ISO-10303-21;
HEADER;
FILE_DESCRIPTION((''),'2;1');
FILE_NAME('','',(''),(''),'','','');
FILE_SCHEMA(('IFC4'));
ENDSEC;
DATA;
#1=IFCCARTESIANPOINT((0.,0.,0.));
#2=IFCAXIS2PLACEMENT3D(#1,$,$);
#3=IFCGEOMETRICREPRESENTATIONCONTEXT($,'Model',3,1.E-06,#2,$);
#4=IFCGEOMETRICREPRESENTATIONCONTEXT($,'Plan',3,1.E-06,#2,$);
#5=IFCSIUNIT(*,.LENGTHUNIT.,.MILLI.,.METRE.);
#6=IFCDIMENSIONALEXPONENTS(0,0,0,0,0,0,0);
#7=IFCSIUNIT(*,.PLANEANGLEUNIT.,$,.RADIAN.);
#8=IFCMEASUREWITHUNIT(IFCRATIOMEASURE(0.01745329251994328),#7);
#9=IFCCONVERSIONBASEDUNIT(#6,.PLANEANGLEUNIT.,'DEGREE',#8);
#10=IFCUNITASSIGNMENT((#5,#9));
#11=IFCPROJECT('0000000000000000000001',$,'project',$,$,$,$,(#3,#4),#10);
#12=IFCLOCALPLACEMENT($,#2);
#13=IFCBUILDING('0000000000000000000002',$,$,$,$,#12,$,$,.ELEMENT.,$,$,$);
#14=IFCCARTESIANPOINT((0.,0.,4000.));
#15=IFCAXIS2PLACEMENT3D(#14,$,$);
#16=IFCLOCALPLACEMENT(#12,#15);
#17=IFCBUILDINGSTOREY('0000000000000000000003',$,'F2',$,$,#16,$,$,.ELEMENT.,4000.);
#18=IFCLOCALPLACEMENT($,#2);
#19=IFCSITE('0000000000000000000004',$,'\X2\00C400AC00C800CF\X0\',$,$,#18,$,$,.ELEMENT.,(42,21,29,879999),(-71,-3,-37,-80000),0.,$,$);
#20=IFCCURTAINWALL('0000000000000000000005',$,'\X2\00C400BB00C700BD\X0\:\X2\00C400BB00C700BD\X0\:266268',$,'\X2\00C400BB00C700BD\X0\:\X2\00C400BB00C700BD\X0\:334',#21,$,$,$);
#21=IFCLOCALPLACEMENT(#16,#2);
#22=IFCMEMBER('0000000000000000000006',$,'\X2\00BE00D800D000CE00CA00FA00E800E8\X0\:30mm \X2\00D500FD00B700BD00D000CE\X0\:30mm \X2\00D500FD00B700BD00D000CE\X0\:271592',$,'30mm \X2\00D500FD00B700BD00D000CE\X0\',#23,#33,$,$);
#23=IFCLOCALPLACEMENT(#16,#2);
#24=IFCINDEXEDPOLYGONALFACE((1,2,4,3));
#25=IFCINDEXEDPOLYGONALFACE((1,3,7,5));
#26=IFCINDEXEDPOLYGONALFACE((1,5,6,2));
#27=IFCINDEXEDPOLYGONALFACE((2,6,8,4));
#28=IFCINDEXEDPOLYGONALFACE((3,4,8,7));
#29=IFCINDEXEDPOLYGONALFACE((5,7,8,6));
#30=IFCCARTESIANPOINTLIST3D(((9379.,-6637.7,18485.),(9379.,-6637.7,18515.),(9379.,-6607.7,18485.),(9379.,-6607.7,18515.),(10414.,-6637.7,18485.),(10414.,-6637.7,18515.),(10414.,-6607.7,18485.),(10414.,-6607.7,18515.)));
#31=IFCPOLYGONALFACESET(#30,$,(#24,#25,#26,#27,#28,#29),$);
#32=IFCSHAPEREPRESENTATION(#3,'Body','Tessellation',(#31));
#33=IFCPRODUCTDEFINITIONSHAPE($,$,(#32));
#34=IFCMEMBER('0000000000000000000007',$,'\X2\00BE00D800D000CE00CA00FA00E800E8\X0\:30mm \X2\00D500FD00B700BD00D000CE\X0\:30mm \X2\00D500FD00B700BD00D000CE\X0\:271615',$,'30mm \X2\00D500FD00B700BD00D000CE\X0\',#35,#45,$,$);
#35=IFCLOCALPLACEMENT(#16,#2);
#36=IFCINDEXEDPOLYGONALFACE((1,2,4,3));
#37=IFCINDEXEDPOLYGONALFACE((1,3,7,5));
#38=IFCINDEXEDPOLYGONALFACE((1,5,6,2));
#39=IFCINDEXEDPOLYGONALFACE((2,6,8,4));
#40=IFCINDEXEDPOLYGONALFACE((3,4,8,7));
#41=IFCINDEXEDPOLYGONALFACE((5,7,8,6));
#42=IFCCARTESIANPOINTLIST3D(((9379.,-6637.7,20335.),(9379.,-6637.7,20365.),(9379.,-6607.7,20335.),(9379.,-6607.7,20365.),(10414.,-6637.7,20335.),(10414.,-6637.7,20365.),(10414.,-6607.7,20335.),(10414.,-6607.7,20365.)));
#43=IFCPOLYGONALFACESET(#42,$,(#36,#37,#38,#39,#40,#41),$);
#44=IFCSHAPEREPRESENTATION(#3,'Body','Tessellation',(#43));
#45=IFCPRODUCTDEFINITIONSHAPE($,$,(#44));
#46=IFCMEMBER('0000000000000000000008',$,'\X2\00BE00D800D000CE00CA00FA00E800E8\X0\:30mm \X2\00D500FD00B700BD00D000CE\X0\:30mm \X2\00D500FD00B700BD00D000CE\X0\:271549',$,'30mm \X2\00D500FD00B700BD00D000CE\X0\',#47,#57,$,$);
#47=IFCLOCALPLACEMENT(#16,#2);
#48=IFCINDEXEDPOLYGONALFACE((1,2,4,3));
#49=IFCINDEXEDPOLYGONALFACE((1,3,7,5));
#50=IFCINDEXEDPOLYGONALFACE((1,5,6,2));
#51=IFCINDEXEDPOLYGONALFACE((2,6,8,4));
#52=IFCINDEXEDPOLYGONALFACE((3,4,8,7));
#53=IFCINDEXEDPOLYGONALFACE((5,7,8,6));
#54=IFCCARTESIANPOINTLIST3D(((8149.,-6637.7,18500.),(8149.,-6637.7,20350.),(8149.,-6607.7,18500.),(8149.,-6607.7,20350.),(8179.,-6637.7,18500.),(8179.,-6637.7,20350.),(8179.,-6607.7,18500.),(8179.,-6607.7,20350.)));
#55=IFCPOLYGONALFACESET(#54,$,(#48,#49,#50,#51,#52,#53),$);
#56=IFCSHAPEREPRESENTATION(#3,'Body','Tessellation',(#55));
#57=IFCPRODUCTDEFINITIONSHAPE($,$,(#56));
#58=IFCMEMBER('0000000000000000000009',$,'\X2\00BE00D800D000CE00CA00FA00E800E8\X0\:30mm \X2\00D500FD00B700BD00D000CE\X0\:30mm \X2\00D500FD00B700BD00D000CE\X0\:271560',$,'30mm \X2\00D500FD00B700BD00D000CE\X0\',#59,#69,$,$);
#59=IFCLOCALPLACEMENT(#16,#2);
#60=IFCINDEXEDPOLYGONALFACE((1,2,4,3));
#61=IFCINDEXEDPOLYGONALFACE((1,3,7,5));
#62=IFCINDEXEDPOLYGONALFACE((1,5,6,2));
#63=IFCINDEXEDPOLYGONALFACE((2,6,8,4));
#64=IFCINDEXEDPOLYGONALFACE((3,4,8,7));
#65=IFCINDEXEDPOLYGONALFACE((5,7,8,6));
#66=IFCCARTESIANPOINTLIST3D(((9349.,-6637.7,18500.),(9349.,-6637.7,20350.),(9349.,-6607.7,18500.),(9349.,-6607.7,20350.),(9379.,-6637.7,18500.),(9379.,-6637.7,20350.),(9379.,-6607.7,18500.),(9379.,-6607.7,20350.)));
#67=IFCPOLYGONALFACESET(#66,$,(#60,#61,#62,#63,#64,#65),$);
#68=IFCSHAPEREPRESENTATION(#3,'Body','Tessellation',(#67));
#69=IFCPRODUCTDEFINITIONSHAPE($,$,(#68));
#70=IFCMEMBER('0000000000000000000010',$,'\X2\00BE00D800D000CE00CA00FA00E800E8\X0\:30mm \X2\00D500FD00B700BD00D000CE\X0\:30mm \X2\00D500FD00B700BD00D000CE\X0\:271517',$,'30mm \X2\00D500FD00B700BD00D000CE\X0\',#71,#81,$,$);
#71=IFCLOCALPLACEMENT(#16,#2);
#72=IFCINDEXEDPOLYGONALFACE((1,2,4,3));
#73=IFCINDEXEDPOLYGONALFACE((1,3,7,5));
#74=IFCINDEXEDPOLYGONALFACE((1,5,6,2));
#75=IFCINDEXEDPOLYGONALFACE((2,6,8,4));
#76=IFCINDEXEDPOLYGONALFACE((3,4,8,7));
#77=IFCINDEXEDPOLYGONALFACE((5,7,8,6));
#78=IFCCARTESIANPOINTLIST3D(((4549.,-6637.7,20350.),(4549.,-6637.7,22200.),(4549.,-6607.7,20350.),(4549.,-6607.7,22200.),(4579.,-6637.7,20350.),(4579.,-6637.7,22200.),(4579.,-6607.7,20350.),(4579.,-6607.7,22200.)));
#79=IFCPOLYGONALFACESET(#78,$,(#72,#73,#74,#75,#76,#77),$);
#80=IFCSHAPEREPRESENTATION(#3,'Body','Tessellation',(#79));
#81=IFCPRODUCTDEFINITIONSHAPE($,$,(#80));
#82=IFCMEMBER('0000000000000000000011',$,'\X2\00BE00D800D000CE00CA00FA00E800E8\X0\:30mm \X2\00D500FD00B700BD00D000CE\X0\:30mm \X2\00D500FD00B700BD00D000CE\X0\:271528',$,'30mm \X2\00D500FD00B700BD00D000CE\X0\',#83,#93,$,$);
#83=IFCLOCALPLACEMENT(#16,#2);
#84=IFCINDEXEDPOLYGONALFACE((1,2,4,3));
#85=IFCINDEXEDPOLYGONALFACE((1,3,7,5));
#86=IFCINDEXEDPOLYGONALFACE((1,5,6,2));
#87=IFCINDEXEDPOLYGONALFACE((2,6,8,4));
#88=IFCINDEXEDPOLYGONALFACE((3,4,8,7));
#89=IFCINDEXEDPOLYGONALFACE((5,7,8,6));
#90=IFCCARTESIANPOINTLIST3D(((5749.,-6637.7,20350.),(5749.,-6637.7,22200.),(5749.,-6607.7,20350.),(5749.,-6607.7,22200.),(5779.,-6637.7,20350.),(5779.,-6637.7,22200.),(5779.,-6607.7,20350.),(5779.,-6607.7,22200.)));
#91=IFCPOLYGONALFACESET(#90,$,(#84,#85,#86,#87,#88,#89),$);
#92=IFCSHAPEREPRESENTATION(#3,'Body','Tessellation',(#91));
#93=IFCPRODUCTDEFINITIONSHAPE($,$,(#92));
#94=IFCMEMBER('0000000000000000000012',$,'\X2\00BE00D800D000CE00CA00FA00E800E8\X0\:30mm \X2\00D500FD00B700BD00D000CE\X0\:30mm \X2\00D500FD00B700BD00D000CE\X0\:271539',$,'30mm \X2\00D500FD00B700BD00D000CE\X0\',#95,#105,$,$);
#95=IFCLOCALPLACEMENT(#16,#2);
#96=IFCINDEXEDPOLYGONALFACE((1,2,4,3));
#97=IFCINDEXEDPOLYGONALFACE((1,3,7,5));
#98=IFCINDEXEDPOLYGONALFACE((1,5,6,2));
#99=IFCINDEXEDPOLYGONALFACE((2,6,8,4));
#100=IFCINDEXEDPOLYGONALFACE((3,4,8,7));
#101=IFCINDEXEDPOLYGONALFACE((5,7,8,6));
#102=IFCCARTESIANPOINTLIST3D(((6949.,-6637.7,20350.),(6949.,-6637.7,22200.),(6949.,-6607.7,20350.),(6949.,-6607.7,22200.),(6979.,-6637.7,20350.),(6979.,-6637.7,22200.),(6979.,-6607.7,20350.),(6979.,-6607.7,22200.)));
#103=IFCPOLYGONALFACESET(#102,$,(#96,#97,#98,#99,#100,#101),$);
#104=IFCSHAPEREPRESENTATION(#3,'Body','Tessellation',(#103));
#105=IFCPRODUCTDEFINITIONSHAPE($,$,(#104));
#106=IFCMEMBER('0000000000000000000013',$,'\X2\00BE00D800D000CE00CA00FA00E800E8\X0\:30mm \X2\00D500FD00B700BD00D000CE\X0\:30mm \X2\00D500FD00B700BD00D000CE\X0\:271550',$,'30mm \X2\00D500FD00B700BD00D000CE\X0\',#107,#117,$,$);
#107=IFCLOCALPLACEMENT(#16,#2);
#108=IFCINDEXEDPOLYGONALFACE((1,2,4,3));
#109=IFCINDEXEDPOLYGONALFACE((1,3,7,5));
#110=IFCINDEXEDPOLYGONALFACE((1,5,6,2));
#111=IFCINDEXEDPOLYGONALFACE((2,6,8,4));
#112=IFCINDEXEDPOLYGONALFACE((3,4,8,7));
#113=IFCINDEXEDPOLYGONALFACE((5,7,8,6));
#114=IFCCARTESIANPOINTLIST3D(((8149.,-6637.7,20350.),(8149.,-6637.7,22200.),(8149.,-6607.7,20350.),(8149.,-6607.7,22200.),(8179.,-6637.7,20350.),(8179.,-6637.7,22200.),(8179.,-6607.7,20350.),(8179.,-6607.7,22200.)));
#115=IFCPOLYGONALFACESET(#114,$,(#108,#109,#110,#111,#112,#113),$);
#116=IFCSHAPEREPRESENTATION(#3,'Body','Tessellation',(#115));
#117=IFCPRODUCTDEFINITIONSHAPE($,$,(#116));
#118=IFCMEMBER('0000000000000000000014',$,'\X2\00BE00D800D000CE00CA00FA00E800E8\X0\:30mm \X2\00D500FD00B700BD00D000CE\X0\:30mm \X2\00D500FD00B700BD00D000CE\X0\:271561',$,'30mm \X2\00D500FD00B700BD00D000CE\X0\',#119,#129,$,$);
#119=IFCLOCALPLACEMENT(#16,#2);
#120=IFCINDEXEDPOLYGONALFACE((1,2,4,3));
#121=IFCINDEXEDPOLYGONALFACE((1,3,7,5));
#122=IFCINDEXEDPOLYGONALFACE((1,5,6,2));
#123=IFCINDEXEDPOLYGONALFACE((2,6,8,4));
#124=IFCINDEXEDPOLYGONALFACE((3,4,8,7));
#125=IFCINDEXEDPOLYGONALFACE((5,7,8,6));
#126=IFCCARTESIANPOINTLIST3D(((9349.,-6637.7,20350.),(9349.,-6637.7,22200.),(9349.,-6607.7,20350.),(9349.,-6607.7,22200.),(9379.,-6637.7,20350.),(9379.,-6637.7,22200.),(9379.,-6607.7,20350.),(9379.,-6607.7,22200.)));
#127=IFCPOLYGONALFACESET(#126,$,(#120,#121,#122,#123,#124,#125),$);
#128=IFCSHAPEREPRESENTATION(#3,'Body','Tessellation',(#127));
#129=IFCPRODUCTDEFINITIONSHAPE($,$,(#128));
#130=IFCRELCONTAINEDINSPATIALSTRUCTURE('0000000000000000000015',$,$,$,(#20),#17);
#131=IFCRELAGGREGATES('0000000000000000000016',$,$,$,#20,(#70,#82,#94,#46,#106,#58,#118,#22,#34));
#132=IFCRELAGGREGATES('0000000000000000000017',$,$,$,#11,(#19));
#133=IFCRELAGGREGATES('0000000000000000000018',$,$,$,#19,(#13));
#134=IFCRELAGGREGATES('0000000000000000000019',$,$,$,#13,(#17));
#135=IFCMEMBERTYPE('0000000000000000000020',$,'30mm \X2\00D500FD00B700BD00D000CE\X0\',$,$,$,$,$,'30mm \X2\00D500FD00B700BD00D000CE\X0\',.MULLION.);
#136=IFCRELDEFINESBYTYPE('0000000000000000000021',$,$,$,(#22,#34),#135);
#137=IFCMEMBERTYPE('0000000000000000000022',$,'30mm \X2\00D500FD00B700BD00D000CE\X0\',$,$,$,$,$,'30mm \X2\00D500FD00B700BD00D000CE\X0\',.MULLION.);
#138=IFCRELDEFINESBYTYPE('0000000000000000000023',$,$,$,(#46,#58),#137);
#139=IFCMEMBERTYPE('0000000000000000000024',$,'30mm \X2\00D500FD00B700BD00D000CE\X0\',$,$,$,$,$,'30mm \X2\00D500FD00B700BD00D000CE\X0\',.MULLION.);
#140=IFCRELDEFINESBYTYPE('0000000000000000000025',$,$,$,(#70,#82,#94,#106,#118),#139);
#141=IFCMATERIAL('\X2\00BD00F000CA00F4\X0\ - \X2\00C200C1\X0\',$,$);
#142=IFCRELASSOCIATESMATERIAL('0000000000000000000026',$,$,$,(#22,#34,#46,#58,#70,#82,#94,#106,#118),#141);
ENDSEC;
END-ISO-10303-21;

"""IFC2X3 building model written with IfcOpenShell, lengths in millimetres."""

from ifc_helpers import new_model, entity, si_unit, converted_unit, frame, origin, origin_2d_with_axis, place, context, project, spatial, rectangle, extrude, source, transform, mapped, material, type_object, type_shapes, element, aggregate, save


model = new_model("IFC2X3")

# Units and contexts
model_context = context("Model", 3, precision=1e-06, world=origin())
plan_context = context("Plan", 3, precision=1e-06, world=origin())
ifc_project = project(units=[si_unit("LENGTHUNIT", "METRE", prefix="MILLI"), converted_unit("PLANEANGLEUNIT", "DEGREE", entity("IfcRatioMeasure", 0.01745329251994328), si_unit("PLANEANGLEUNIT", "RADIAN"), dimensions=[0, 0, 0, 0, 0, 0, 0])], contexts=[model_context, plan_context])

# Site, building, storey
site_placement = place(None, origin())
site = spatial("IfcSite", under=ifc_project, at=site_placement, Name="Ä¬ÈÏ", CompositionType="ELEMENT", RefLatitude=(42, 21, 29, 879999), RefLongitude=(-71, -3, -37, -80000), RefElevation=0.0)
building_placement = place(None, origin())
building = spatial("IfcBuilding", under=site, at=building_placement, CompositionType="ELEMENT")
storey_placement = place(building_placement, frame((0.0, 0.0, 4000.0)))
storey = spatial("IfcBuildingStorey", under=building, at=storey_placement, Name="F2", CompositionType="ELEMENT", Elevation=4000.0)

# Curtain wall, members
curtain_wall_placement = place(storey_placement, origin())
curtain_wall = element("IfcCurtainWall", 1, at=curtain_wall_placement, inside=storey, Name="Ä»Ç½:Ä»Ç½:266268", ObjectType="Ä»Ç½:Ä»Ç½:334")
ifc_material_1 = material(Name="½ðÊô - ÂÁ")
placement_1 = place(building_placement, frame((0.0, 0.0, 22500.0)))
member_type_1 = type_object("IfcMemberType", Name="30mm Õý·½ÐÎ", ElementType="30mm Õý·½ÐÎ", PredefinedType="MULLION")
shared_shape_1 = source(origin(), model_context, "Body", "SweptSolid", [
    extrude(rectangle(XDim=30.0, YDim=30.0, at=origin_2d_with_axis()), frame((0.0, 0.0, -1035.0), z_axis=(0.0, 0.0, 1.0), x_axis=(-1.0, 0.0, 0.0)), (0.0, 0.0, 1.0), 1035.0),
])
type_shapes(member_type_1, [shared_shape_1])
member_1_placement = place(placement_1, frame((10414.0, -6622.7, 0.0), z_axis=(1.0, 0.0, 0.0), x_axis=(0.0, 0.0, 1.0)))
member_1 = element("IfcMember", 2, at=member_1_placement, type_object=member_type_1, material=ifc_material_1, Name="¾ØÐÎÊúèè:30mm Õý·½ÐÎ:30mm Õý·½ÐÎ:271592", ObjectType="30mm Õý·½ÐÎ", context=model_context, shape_type="MappedRepresentation", body=[
    mapped(shared_shape_1, transform((0.0, 0.0, 0.0), scale=1.0)),
])
member_2_placement = place(placement_1, frame((10414.0, -6622.7, 1850.0), z_axis=(1.0, 0.0, 0.0), x_axis=(0.0, 0.0, 1.0)))
member_2 = element("IfcMember", 3, at=member_2_placement, type_object=member_type_1, material=ifc_material_1, Name="¾ØÐÎÊúèè:30mm Õý·½ÐÎ:30mm Õý·½ÐÎ:271615", ObjectType="30mm Õý·½ÐÎ", context=model_context, shape_type="MappedRepresentation", body=[
    mapped(shared_shape_1, transform((0.0, 0.0, 0.0), scale=1.0)),
])
member_type_2 = type_object("IfcMemberType", Name="30mm Õý·½ÐÎ", ElementType="30mm Õý·½ÐÎ", PredefinedType="MULLION")
shared_shape_2 = source(origin(), model_context, "Body", "SweptSolid", [
    extrude(rectangle(XDim=30.0, YDim=30.0, at=origin_2d_with_axis()), frame((0.0, 0.0, -1850.0), z_axis=(0.0, 0.0, 1.0), x_axis=(-1.0, 0.0, 0.0)), (0.0, 0.0, 1.0), 1850.0),
])
type_shapes(member_type_2, [shared_shape_2])
member_3_placement = place(placement_1, frame((8164.0, -6622.7, 0.0), z_axis=(0.0, 0.0, -1.0), x_axis=(1.0, 0.0, 0.0)))
member_3 = element("IfcMember", 4, at=member_3_placement, type_object=member_type_2, material=ifc_material_1, Name="¾ØÐÎÊúèè:30mm Õý·½ÐÎ:30mm Õý·½ÐÎ:271549", ObjectType="30mm Õý·½ÐÎ", context=model_context, shape_type="MappedRepresentation", body=[
    mapped(shared_shape_2, transform((0.0, 0.0, 0.0), scale=1.0)),
])
member_4_placement = place(placement_1, frame((9364.0, -6622.7, 0.0), z_axis=(0.0, 0.0, -1.0), x_axis=(1.0, 0.0, 0.0)))
member_4 = element("IfcMember", 5, at=member_4_placement, type_object=member_type_2, material=ifc_material_1, Name="¾ØÐÎÊúèè:30mm Õý·½ÐÎ:30mm Õý·½ÐÎ:271560", ObjectType="30mm Õý·½ÐÎ", context=model_context, shape_type="MappedRepresentation", body=[
    mapped(shared_shape_2, transform((0.0, 0.0, 0.0), scale=1.0)),
])
member_type_3 = type_object("IfcMemberType", Name="30mm Õý·½ÐÎ", ElementType="30mm Õý·½ÐÎ", PredefinedType="MULLION")
shared_shape_3 = source(origin(), model_context, "Body", "SweptSolid", [
    extrude(rectangle(XDim=30.0, YDim=30.0, at=origin_2d_with_axis()), frame((0.0, 0.0, -1850.0), z_axis=(0.0, 0.0, 1.0), x_axis=(-1.0, 0.0, 0.0)), (0.0, 0.0, 1.0), 1850.0),
])
type_shapes(member_type_3, [shared_shape_3])
member_5_placement = place(placement_1, frame((4564.0, -6622.7, 1850.0), z_axis=(0.0, 0.0, -1.0), x_axis=(1.0, 0.0, 0.0)))
member_5 = element("IfcMember", 6, at=member_5_placement, type_object=member_type_3, material=ifc_material_1, Name="¾ØÐÎÊúèè:30mm Õý·½ÐÎ:30mm Õý·½ÐÎ:271517", ObjectType="30mm Õý·½ÐÎ", context=model_context, shape_type="MappedRepresentation", body=[
    mapped(shared_shape_3, transform((0.0, 0.0, 0.0), scale=1.0)),
])
member_6_placement = place(placement_1, frame((5764.0, -6622.7, 1850.0), z_axis=(0.0, 0.0, -1.0), x_axis=(1.0, 0.0, 0.0)))
member_6 = element("IfcMember", 7, at=member_6_placement, type_object=member_type_3, material=ifc_material_1, Name="¾ØÐÎÊúèè:30mm Õý·½ÐÎ:30mm Õý·½ÐÎ:271528", ObjectType="30mm Õý·½ÐÎ", context=model_context, shape_type="MappedRepresentation", body=[
    mapped(shared_shape_3, transform((0.0, 0.0, 0.0), scale=1.0)),
])
member_7_placement = place(placement_1, frame((6964.0, -6622.7, 1850.0), z_axis=(0.0, 0.0, -1.0), x_axis=(1.0, 0.0, 0.0)))
member_7 = element("IfcMember", 8, at=member_7_placement, type_object=member_type_3, material=ifc_material_1, Name="¾ØÐÎÊúèè:30mm Õý·½ÐÎ:30mm Õý·½ÐÎ:271539", ObjectType="30mm Õý·½ÐÎ", context=model_context, shape_type="MappedRepresentation", body=[
    mapped(shared_shape_3, transform((0.0, 0.0, 0.0), scale=1.0)),
])
member_8_placement = place(placement_1, frame((8164.0, -6622.7, 1850.0), z_axis=(0.0, 0.0, -1.0), x_axis=(1.0, 0.0, 0.0)))
member_8 = element("IfcMember", 9, at=member_8_placement, type_object=member_type_3, material=ifc_material_1, Name="¾ØÐÎÊúèè:30mm Õý·½ÐÎ:30mm Õý·½ÐÎ:271550", ObjectType="30mm Õý·½ÐÎ", context=model_context, shape_type="MappedRepresentation", body=[
    mapped(shared_shape_3, transform((0.0, 0.0, 0.0), scale=1.0)),
])
member_9_placement = place(placement_1, frame((9364.0, -6622.7, 1850.0), z_axis=(0.0, 0.0, -1.0), x_axis=(1.0, 0.0, 0.0)))
member_9 = element("IfcMember", 10, at=member_9_placement, type_object=member_type_3, material=ifc_material_1, Name="¾ØÐÎÊúèè:30mm Õý·½ÐÎ:30mm Õý·½ÐÎ:271561", ObjectType="30mm Õý·½ÐÎ", context=model_context, shape_type="MappedRepresentation", body=[
    mapped(shared_shape_3, transform((0.0, 0.0, 0.0), scale=1.0)),
])
aggregate(curtain_wall, [member_5, member_6, member_7, member_3, member_8, member_4, member_9, member_1, member_2])

save(model, "model.ifc")
